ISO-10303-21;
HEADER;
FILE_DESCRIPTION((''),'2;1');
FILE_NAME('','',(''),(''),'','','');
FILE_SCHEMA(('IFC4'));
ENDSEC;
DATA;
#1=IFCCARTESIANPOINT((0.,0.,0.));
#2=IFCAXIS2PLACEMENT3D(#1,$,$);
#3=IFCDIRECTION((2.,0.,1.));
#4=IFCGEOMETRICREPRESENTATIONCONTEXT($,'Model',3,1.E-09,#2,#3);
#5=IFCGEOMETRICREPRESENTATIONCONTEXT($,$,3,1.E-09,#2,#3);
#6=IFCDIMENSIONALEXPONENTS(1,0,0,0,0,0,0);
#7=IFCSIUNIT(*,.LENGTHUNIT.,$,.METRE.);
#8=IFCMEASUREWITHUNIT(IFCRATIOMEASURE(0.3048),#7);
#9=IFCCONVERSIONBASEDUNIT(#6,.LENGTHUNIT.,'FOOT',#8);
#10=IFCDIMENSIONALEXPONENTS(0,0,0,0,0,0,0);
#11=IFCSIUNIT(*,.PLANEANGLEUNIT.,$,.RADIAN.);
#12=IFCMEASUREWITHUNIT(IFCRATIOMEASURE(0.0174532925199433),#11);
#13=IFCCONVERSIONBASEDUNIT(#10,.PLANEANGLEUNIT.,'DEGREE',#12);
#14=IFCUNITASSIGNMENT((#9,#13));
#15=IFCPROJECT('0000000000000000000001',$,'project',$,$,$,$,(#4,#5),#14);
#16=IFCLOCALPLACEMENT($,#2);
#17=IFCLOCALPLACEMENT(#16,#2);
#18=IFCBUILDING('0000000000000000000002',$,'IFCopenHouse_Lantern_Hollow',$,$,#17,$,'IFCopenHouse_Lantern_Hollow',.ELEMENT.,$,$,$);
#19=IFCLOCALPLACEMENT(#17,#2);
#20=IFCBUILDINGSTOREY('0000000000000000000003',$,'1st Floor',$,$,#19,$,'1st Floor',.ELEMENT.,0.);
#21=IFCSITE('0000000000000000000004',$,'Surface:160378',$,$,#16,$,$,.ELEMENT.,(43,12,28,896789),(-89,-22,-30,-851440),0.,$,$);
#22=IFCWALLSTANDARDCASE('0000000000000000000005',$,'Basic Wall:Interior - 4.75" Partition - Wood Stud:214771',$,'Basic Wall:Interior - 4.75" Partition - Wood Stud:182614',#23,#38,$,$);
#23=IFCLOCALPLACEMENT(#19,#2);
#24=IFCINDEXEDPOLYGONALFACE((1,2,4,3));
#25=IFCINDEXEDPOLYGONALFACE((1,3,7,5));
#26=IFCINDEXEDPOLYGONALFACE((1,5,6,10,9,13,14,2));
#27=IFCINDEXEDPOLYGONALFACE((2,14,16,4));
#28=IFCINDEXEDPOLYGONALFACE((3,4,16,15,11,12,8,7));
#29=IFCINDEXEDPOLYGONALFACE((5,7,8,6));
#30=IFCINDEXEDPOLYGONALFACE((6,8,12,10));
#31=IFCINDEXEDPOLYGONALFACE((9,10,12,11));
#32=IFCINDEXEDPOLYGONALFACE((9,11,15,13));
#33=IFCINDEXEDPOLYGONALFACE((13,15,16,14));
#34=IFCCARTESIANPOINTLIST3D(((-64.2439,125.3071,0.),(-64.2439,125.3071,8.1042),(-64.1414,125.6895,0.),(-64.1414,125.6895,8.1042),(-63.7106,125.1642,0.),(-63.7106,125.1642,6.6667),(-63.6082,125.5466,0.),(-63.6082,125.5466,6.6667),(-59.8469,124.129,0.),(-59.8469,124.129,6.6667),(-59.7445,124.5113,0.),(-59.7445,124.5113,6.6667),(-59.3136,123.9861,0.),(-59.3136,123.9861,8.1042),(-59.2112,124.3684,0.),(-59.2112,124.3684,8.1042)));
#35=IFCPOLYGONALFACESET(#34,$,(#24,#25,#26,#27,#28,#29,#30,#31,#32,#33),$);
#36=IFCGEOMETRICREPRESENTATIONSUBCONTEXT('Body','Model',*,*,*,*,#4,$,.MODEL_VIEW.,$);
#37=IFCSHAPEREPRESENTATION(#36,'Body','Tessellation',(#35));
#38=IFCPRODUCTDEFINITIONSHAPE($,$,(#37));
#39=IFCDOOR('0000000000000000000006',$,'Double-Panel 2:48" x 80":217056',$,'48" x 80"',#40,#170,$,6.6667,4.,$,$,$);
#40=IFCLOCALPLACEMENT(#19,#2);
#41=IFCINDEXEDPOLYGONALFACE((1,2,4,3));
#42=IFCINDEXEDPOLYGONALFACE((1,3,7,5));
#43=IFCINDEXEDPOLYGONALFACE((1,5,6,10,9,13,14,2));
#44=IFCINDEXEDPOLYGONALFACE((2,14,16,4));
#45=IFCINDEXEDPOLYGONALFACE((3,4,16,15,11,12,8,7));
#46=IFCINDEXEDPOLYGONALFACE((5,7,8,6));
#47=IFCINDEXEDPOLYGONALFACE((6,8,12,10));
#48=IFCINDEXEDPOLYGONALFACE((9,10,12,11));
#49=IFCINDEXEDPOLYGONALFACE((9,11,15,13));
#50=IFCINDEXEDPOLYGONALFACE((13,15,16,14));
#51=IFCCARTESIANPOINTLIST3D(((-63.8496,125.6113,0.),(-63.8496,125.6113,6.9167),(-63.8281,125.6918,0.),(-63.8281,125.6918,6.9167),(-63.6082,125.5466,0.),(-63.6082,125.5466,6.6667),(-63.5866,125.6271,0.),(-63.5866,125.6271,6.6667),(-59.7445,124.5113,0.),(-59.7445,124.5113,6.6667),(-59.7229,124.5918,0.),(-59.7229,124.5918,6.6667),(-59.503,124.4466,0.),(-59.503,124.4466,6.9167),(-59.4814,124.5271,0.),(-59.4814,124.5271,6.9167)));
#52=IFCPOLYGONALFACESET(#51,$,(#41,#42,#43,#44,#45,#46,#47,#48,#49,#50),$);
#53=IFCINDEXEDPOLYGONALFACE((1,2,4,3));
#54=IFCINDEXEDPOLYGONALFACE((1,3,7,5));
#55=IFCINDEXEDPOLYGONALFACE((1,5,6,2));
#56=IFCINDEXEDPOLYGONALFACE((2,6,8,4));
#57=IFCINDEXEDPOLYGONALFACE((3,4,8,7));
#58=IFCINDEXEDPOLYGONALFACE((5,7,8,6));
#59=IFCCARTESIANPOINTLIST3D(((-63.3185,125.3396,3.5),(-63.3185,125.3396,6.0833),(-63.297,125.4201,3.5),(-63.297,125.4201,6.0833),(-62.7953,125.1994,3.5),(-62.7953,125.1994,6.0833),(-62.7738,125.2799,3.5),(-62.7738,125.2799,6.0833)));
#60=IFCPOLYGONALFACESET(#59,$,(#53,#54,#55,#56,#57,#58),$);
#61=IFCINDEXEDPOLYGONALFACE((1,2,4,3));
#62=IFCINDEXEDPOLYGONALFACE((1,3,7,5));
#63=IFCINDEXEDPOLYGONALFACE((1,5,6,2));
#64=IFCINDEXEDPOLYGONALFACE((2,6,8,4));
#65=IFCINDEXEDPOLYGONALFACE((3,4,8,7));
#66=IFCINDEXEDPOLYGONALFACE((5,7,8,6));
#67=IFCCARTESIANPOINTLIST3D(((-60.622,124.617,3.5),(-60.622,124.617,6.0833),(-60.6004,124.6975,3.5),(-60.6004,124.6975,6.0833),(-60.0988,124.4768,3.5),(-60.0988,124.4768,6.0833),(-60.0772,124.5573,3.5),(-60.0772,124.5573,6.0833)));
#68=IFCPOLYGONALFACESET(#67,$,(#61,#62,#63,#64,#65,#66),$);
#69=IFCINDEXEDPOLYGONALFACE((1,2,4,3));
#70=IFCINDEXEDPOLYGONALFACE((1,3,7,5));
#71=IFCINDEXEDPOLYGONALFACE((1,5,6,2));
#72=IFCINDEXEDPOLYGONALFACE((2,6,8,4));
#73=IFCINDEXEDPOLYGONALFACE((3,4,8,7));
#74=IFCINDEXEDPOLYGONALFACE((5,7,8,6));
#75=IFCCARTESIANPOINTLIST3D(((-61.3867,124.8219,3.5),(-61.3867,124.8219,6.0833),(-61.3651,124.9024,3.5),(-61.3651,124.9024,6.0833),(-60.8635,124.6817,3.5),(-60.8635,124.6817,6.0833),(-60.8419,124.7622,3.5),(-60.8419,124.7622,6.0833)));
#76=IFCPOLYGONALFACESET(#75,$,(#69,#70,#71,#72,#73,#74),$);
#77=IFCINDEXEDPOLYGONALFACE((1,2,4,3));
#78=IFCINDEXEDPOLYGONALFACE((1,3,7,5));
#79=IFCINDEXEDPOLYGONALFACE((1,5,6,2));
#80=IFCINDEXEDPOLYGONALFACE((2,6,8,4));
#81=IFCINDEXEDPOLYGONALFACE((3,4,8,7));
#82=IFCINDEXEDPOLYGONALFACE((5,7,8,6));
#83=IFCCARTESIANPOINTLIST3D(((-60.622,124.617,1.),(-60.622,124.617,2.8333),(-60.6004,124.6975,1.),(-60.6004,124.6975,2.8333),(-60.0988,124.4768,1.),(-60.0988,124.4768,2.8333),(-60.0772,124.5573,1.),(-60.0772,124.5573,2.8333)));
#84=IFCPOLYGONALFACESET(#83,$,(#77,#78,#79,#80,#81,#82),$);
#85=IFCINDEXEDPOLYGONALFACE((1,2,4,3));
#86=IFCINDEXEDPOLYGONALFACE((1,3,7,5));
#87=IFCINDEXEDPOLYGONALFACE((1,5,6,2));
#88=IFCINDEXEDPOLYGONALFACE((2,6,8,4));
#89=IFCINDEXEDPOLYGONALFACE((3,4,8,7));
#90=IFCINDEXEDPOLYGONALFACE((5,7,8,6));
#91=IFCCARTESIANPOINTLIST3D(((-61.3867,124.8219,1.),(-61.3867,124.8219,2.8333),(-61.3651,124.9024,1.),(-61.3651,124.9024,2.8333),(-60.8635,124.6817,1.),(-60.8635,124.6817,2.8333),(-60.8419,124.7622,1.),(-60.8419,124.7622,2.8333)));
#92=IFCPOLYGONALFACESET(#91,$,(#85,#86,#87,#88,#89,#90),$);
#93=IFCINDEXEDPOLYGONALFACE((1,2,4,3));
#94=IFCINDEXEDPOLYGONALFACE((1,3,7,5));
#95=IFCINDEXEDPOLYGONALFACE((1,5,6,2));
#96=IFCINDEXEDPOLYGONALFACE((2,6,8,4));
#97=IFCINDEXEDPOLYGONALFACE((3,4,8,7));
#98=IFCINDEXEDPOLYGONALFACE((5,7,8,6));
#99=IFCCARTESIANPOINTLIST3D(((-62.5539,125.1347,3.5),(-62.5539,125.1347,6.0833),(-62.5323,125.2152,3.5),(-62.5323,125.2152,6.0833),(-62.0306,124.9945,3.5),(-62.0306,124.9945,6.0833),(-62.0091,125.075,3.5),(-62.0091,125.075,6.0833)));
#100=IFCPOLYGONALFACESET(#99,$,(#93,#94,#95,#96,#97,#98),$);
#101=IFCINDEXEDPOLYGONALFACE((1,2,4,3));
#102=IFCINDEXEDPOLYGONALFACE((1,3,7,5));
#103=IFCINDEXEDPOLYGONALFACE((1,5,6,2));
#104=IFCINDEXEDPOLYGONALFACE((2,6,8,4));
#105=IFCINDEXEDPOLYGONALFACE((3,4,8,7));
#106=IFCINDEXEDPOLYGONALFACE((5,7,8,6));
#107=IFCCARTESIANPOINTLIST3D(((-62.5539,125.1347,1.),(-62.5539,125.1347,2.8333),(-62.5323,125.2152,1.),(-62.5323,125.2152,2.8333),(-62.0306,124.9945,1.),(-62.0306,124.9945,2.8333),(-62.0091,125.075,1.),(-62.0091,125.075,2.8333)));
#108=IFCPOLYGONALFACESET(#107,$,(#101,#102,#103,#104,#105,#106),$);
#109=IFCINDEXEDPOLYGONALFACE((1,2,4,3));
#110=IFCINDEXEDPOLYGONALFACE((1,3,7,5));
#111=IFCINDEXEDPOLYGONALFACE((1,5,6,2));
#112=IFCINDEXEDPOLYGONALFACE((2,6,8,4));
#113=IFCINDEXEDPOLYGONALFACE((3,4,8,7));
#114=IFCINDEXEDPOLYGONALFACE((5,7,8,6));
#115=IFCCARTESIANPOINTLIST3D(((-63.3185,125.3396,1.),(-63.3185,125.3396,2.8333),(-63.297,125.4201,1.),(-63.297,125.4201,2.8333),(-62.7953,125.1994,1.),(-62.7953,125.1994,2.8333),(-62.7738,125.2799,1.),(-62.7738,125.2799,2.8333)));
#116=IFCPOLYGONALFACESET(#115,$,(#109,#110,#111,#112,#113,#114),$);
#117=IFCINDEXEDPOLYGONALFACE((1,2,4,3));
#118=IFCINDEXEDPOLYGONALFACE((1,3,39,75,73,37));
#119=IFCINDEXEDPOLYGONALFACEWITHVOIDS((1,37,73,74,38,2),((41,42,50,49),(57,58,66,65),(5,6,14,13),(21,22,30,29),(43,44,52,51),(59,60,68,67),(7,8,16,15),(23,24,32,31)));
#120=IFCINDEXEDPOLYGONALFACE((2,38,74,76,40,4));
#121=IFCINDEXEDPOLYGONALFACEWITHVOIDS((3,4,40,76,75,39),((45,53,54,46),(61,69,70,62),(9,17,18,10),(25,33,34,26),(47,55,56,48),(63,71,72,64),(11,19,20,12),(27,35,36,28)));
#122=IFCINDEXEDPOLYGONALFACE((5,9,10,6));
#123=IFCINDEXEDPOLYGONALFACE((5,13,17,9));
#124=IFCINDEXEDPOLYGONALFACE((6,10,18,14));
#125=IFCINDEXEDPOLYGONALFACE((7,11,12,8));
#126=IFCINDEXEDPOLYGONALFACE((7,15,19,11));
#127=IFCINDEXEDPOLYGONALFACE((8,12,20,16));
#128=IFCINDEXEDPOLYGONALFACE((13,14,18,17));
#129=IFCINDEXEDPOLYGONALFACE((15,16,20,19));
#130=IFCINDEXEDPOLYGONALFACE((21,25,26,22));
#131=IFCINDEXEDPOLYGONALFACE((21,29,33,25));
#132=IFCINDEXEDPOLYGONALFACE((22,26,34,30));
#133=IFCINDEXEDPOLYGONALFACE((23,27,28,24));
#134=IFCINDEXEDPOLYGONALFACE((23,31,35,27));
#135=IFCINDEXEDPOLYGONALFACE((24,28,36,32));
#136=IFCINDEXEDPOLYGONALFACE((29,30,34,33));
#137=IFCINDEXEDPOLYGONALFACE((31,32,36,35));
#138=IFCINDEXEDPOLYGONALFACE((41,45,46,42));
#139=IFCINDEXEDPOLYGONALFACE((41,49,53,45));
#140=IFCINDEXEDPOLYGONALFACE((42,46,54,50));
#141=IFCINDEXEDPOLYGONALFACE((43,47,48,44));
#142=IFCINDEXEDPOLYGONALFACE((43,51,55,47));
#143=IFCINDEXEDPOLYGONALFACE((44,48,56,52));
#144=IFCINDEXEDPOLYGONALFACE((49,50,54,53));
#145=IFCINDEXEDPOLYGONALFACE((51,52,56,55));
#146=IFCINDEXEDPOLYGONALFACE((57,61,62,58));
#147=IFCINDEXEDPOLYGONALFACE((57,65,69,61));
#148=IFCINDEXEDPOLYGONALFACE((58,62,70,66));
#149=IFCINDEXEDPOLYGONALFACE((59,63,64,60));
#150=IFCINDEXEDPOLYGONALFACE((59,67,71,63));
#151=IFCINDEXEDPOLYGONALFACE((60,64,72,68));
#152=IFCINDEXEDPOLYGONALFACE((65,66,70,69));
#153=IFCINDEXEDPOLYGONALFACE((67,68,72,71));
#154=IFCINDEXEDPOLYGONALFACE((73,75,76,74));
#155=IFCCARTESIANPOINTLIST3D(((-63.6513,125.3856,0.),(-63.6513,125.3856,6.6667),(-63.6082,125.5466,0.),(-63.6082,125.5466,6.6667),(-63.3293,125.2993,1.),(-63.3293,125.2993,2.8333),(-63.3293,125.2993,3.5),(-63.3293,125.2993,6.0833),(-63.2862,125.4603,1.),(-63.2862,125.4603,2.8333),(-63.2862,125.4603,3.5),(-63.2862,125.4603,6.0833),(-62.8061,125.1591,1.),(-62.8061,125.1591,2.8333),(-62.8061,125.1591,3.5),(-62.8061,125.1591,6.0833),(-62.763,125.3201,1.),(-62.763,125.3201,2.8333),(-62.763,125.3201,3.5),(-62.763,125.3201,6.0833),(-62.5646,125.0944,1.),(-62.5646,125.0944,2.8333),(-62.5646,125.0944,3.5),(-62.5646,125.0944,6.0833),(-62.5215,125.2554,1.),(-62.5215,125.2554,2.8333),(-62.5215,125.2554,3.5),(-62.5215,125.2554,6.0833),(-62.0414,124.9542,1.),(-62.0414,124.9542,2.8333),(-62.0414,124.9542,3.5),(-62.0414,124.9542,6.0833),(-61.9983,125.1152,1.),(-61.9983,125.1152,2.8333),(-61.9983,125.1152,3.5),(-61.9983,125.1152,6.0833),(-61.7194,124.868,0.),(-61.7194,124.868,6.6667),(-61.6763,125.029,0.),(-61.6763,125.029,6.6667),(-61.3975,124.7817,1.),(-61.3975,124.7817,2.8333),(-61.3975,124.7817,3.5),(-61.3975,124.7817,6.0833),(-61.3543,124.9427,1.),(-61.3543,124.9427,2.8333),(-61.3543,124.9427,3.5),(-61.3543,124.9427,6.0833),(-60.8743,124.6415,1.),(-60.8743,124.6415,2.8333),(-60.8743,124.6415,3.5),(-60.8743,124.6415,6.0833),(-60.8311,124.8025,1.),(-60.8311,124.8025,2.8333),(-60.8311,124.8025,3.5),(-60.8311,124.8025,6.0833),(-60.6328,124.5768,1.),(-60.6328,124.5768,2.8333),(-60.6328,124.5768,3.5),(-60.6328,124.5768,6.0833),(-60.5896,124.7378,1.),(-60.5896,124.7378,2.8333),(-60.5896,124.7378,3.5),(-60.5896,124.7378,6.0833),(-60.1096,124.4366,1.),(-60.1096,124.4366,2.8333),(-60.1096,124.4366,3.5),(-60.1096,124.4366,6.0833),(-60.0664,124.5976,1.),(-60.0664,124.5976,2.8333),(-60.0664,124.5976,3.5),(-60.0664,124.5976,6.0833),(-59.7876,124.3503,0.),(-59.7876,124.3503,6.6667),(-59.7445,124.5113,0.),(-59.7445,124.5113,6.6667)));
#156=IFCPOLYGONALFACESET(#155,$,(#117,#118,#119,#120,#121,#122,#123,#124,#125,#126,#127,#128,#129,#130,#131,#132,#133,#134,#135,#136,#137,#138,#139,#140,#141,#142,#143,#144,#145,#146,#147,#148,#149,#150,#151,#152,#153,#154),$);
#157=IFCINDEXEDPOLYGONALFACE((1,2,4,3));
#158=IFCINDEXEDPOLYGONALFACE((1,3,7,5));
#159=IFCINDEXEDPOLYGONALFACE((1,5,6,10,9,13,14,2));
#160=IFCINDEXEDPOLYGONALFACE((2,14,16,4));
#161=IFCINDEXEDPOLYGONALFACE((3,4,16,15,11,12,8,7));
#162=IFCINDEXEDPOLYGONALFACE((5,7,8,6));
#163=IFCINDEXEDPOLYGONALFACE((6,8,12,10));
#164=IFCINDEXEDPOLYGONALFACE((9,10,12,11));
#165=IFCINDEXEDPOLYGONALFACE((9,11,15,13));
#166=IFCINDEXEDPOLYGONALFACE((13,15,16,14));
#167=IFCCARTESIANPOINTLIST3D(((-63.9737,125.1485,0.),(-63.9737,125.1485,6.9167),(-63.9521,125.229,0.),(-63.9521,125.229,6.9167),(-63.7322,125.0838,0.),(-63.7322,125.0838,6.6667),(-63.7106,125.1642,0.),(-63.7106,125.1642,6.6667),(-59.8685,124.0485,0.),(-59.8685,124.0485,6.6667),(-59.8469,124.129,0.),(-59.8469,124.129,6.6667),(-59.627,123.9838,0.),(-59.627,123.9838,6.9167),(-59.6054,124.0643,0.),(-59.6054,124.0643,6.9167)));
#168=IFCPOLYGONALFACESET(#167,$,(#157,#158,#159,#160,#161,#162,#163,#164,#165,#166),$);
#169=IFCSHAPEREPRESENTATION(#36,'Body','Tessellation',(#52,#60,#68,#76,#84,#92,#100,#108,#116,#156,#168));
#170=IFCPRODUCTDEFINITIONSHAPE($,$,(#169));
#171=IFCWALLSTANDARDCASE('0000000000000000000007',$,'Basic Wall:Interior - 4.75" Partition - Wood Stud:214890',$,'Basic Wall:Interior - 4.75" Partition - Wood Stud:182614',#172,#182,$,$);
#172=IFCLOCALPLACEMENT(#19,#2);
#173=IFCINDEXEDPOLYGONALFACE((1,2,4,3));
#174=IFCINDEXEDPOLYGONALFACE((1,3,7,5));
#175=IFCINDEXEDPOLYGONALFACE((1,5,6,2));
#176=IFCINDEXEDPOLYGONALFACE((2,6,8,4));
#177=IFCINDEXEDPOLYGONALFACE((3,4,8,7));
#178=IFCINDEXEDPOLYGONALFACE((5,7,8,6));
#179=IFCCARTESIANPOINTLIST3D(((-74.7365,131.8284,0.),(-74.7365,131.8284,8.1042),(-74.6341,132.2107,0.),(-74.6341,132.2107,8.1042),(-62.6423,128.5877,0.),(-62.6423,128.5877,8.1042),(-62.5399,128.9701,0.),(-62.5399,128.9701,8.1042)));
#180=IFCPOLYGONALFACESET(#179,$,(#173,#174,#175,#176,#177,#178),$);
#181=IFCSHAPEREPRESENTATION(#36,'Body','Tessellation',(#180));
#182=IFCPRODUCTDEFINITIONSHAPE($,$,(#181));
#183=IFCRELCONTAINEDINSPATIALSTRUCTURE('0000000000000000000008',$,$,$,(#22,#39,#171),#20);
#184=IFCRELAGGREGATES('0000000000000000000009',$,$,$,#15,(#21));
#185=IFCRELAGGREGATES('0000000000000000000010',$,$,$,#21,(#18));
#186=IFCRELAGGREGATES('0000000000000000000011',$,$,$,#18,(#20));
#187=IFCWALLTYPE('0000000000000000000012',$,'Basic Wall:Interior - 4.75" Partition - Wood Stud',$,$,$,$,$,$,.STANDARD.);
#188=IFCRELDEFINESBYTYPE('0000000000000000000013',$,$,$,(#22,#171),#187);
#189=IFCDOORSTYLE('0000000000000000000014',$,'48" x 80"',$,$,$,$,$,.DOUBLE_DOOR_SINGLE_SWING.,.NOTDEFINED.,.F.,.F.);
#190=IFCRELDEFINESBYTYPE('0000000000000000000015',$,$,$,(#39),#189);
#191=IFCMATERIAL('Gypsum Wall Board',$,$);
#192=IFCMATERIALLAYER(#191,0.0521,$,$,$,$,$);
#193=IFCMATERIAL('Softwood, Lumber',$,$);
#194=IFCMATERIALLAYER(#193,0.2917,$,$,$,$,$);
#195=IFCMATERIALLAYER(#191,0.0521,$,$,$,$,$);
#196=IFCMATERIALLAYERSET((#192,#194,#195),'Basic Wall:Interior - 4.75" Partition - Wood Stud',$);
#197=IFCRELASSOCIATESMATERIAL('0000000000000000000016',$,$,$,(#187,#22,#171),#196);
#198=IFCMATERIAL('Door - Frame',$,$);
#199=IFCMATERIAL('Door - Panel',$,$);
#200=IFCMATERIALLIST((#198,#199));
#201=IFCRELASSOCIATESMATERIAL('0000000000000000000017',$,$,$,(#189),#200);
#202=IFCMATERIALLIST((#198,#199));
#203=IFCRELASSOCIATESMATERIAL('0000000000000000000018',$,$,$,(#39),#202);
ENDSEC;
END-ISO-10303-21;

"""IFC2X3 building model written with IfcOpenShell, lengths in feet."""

from ifc_helpers import new_model, entity, si_unit, converted_unit, direction, frame, frame_2d, origin, place, context, subcontext, project, spatial, polyline, rectangle, outline, extrude, source, transform, mapped, material, material_list, layer, layer_set, layer_usage, type_object, type_shapes, element, fill, save


model = new_model("IFC2X3")

# Units and contexts
model_context = context("Model", 3, precision=1e-09, world=origin(), true_north=direction((2.0, 0.0, 1.0)))
context_of_model = context(None, 3, precision=1e-09, world=origin(), true_north=direction((2.0, 0.0, 1.0)))
body_context = subcontext(model_context, "Body", "Model", "MODEL_VIEW")
ifc_project = project(units=[converted_unit("LENGTHUNIT", "FOOT", entity("IfcRatioMeasure", 0.3048), si_unit("LENGTHUNIT", "METRE"), dimensions=[1, 0, 0, 0, 0, 0, 0]), converted_unit("PLANEANGLEUNIT", "DEGREE", entity("IfcRatioMeasure", 0.0174532925199433), si_unit("PLANEANGLEUNIT", "RADIAN"), dimensions=[0, 0, 0, 0, 0, 0, 0])], contexts=[model_context, context_of_model])

# Site, building, storey
site_placement = place(None, origin())
site = spatial("IfcSite", under=ifc_project, at=site_placement, Name="Surface:160378", CompositionType="ELEMENT", RefLatitude=(43, 12, 28, 896789), RefLongitude=(-89, -22, -30, -851440), RefElevation=0.0)
building_placement = place(site_placement, origin())
building = spatial("IfcBuilding", under=site, at=building_placement, Name="IFCopenHouse_Lantern_Hollow", LongName="IFCopenHouse_Lantern_Hollow", CompositionType="ELEMENT")
storey_placement = place(building_placement, origin())
storey = spatial("IfcBuildingStorey", under=building, at=storey_placement, Name="1st Floor", LongName="1st Floor", CompositionType="ELEMENT", Elevation=0.0)

# Shared definitions
ifc_material_1 = material(Name="Softwood, Lumber")

# Shared definitions
ifc_material_2 = material(Name="Gypsum Wall Board")

# Shared definitions
ifc_layer_1 = layer(ifc_material_2, 0.0521)
ifc_layer_2 = layer(ifc_material_1, 0.2917)
ifc_layer_3 = layer(ifc_material_2, 0.0521)
ifc_layer_set_1 = layer_set([ifc_layer_1, ifc_layer_2, ifc_layer_3], Name="Basic Wall:Interior - 4.75\" Partition - Wood Stud")
wall_type_1 = type_object("IfcWallType", Name="Basic Wall:Interior - 4.75\" Partition - Wood Stud", PredefinedType="STANDARD", material=ifc_layer_set_1)

# Shared definitions
ifc_material_3 = material(Name="Door - Panel")
ifc_material_4 = material(Name="Door - Frame")

# Wall, opening, door
ifc_layer_usage_1 = layer_usage(ifc_layer_set_1, "AXIS2", "NEGATIVE", 0.1979)
wall_1_placement = place(storey_placement, frame((-59.2624, 124.1773, 0.0), z_axis=(0.0, 0.0, 1.0), x_axis=(-0.965926, 0.258819, 0.0)))
wall_1 = element("IfcWallStandardCase", 1, at=wall_1_placement, inside=storey, type_object=wall_type_1, material=ifc_layer_usage_1, Name="Basic Wall:Interior - 4.75\" Partition - Wood Stud:214771", ObjectType="Basic Wall:Interior - 4.75\" Partition - Wood Stud:182614", context=body_context, shape_type="SweptSolid", body=[
    extrude(rectangle(XDim=5.1042, YDim=0.3958, at=frame_2d((2.5521, 0.0), x_axis=(-1.0, 0.0))), origin(), (0.0, 0.0, 1.0), 8.1042),
])
opening_1_placement = place(wall_1_placement, frame((4.5521, 0.1979, 0.0)))
opening_1 = element("IfcOpeningElement", 2, at=opening_1_placement, cuts=wall_1, ObjectType="Opening", context=body_context, shape_type="SweptSolid", body=[
    extrude(rectangle(XDim=6.6667, YDim=4.0, at=frame_2d((3.3333, 2.0), x_axis=(1.0, 0.0))), frame((0.0, 0.0, 0.0), z_axis=(0.0, -1.0, 0.0), x_axis=(0.0, 0.0, 1.0)), (0.0, 0.0, 1.0), 0.3958),
])
ifc_material_list_1 = material_list([ifc_material_4, ifc_material_3])
ifc_material_list_2 = material_list([ifc_material_4, ifc_material_3])
door_style_1 = type_object("IfcDoorStyle", Name="48\" x 80\"", ConstructionType="NOTDEFINED", OperationType="DOUBLE_DOOR_SINGLE_SWING", ParameterTakesPrecedence=False, Sizeable=False, material=ifc_material_list_2)
shared_shape_1 = source(origin(), body_context, "Body", "SweptSolid", [
    extrude(outline(polyline([(-2.25, -3.5208), (2.25, -3.5208), (2.25, 3.3958), (2.0, 3.3958), (2.0, -3.2708), (-2.0, -3.2708), (-2.0, 3.3958), (-2.25, 3.3958), (-2.25, -3.5208)])), frame((2.0, 0.3958, 3.3958), z_axis=(0.0, 1.0, 0.0), x_axis=(1.0, 0.0, 0.0)), (0.0, 0.0, 1.0), 0.0833),
    extrude(rectangle(XDim=0.0833, YDim=0.5417, at=frame_2d((0.0, 0.0), x_axis=(1.0, 0.0))), frame((0.6042, 0.3125, 3.5), z_axis=(0.0, 0.0, 1.0), x_axis=(0.0, -1.0, 0.0)), (0.0, 0.0, 1.0), 2.5833),
    extrude(rectangle(XDim=0.0833, YDim=0.5417, at=frame_2d((0.0, 0.0), x_axis=(1.0, 0.0))), frame((3.3958, 0.3125, 3.5), z_axis=(0.0, 0.0, 1.0), x_axis=(0.0, -1.0, 0.0)), (0.0, 0.0, 1.0), 2.5833),
    extrude(rectangle(XDim=0.0833, YDim=0.5417, at=frame_2d((0.0, 0.0), x_axis=(1.0, 0.0))), frame((2.6042, 0.3125, 3.5), z_axis=(0.0, 0.0, 1.0), x_axis=(0.0, -1.0, 0.0)), (0.0, 0.0, 1.0), 2.5833),
    extrude(rectangle(XDim=0.0833, YDim=0.5417, at=frame_2d((0.0, 0.0), x_axis=(1.0, 0.0))), frame((3.3958, 0.3125, 1.0), z_axis=(0.0, 0.0, 1.0), x_axis=(0.0, -1.0, 0.0)), (0.0, 0.0, 1.0), 1.8333),
    extrude(rectangle(XDim=0.0833, YDim=0.5417, at=frame_2d((0.0, 0.0), x_axis=(1.0, 0.0))), frame((2.6042, 0.3125, 1.0), z_axis=(0.0, 0.0, 1.0), x_axis=(0.0, -1.0, 0.0)), (0.0, 0.0, 1.0), 1.8333),
    extrude(rectangle(XDim=0.0833, YDim=0.5417, at=frame_2d((0.0, 0.0), x_axis=(1.0, 0.0))), frame((1.3958, 0.3125, 3.5), z_axis=(0.0, 0.0, 1.0), x_axis=(0.0, -1.0, 0.0)), (0.0, 0.0, 1.0), 2.5833),
    extrude(rectangle(XDim=0.0833, YDim=0.5417, at=frame_2d((0.0, 0.0), x_axis=(1.0, 0.0))), frame((1.3958, 0.3125, 1.0), z_axis=(0.0, 0.0, 1.0), x_axis=(0.0, -1.0, 0.0)), (0.0, 0.0, 1.0), 1.8333),
    extrude(rectangle(XDim=0.0833, YDim=0.5417, at=frame_2d((0.0, 0.0), x_axis=(1.0, 0.0))), frame((0.6042, 0.3125, 1.0), z_axis=(0.0, 0.0, 1.0), x_axis=(0.0, -1.0, 0.0)), (0.0, 0.0, 1.0), 1.8333),
    extrude(outline(polyline([(0.0, -3.3333), (2.0, -3.3333), (2.0, 3.3333), (0.0, 3.3333), (-2.0, 3.3333), (-2.0, -3.3333), (0.0, -3.3333)]), holes=[polyline([(1.125, -2.75), (1.125, -0.1667), (1.6667, -0.1667), (1.6667, -2.75), (1.125, -2.75)]), polyline([(0.3333, -2.75), (0.3333, -0.1667), (0.875, -0.1667), (0.875, -2.75), (0.3333, -2.75)]), polyline([(1.125, 0.5), (1.125, 2.3333), (1.6667, 2.3333), (1.6667, 0.5), (1.125, 0.5)]), polyline([(0.3333, 0.5), (0.3333, 2.3333), (0.875, 2.3333), (0.875, 0.5), (0.3333, 0.5)]), polyline([(-0.875, -0.1667), (-0.3333, -0.1667), (-0.3333, -2.75), (-0.875, -2.75), (-0.875, -0.1667)]), polyline([(-1.6667, -2.75), (-1.6667, -0.1667), (-1.125, -0.1667), (-1.125, -2.75), (-1.6667, -2.75)]), polyline([(-0.875, 0.5), (-0.875, 2.3333), (-0.3333, 2.3333), (-0.3333, 0.5), (-0.875, 0.5)]), polyline([(-1.6667, 0.5), (-1.6667, 2.3333), (-1.125, 2.3333), (-1.125, 0.5), (-1.6667, 0.5)])]), frame((2.0, 0.2292, 3.3333), z_axis=(0.0, 1.0, 0.0), x_axis=(1.0, 0.0, 0.0)), (0.0, 0.0, 1.0), 0.1667),
    extrude(outline(polyline([(-3.2708, 2.0), (3.3958, 2.0), (3.3958, 2.25), (-3.5208, 2.25), (-3.5208, -2.25), (3.3958, -2.25), (3.3958, -2.0), (-3.2708, -2.0), (-3.2708, 2.0)])), frame((2.0, -0.0833, 3.3958), z_axis=(0.0, 1.0, 0.0), x_axis=(0.0, 0.0, -1.0)), (0.0, 0.0, 1.0), 0.0833),
])
type_shapes(door_style_1, [shared_shape_1])
door_1_placement = place(storey_placement, frame((-63.7106, 125.1642, 0.0), z_axis=(0.0, 0.0, 1.0), x_axis=(0.965926, -0.258819, 0.0)))
door_1 = element("IfcDoor", 3, at=door_1_placement, inside=storey, type_object=door_style_1, material=ifc_material_list_1, Name="Double-Panel 2:48\" x 80\":217056", ObjectType="48\" x 80\"", OverallHeight=6.6667, OverallWidth=4.0, context=body_context, shape_type="MappedRepresentation", body=[
    mapped(shared_shape_1, transform((0.0, 0.0, 0.0), scale=1.0)),
])
fill(opening_1, door_1)

# Wall
ifc_layer_usage_2 = layer_usage(ifc_layer_set_1, "AXIS2", "NEGATIVE", 0.1979)
wall_2_placement = place(storey_placement, frame((-62.5911, 128.7789, 0.0), z_axis=(0.0, 0.0, 1.0), x_axis=(-0.965926, 0.258819, 0.0)))
element("IfcWallStandardCase", 4, at=wall_2_placement, inside=storey, type_object=wall_type_1, material=ifc_layer_usage_2, Name="Basic Wall:Interior - 4.75\" Partition - Wood Stud:214890", ObjectType="Basic Wall:Interior - 4.75\" Partition - Wood Stud:182614", context=body_context, shape_type="SweptSolid", body=[
    extrude(rectangle(XDim=12.5208, YDim=0.3958, at=frame_2d((6.2604, 0.0), x_axis=(-1.0, 0.0))), origin(), (0.0, 0.0, 1.0), 8.1042),
])

save(model, "model.ifc")
